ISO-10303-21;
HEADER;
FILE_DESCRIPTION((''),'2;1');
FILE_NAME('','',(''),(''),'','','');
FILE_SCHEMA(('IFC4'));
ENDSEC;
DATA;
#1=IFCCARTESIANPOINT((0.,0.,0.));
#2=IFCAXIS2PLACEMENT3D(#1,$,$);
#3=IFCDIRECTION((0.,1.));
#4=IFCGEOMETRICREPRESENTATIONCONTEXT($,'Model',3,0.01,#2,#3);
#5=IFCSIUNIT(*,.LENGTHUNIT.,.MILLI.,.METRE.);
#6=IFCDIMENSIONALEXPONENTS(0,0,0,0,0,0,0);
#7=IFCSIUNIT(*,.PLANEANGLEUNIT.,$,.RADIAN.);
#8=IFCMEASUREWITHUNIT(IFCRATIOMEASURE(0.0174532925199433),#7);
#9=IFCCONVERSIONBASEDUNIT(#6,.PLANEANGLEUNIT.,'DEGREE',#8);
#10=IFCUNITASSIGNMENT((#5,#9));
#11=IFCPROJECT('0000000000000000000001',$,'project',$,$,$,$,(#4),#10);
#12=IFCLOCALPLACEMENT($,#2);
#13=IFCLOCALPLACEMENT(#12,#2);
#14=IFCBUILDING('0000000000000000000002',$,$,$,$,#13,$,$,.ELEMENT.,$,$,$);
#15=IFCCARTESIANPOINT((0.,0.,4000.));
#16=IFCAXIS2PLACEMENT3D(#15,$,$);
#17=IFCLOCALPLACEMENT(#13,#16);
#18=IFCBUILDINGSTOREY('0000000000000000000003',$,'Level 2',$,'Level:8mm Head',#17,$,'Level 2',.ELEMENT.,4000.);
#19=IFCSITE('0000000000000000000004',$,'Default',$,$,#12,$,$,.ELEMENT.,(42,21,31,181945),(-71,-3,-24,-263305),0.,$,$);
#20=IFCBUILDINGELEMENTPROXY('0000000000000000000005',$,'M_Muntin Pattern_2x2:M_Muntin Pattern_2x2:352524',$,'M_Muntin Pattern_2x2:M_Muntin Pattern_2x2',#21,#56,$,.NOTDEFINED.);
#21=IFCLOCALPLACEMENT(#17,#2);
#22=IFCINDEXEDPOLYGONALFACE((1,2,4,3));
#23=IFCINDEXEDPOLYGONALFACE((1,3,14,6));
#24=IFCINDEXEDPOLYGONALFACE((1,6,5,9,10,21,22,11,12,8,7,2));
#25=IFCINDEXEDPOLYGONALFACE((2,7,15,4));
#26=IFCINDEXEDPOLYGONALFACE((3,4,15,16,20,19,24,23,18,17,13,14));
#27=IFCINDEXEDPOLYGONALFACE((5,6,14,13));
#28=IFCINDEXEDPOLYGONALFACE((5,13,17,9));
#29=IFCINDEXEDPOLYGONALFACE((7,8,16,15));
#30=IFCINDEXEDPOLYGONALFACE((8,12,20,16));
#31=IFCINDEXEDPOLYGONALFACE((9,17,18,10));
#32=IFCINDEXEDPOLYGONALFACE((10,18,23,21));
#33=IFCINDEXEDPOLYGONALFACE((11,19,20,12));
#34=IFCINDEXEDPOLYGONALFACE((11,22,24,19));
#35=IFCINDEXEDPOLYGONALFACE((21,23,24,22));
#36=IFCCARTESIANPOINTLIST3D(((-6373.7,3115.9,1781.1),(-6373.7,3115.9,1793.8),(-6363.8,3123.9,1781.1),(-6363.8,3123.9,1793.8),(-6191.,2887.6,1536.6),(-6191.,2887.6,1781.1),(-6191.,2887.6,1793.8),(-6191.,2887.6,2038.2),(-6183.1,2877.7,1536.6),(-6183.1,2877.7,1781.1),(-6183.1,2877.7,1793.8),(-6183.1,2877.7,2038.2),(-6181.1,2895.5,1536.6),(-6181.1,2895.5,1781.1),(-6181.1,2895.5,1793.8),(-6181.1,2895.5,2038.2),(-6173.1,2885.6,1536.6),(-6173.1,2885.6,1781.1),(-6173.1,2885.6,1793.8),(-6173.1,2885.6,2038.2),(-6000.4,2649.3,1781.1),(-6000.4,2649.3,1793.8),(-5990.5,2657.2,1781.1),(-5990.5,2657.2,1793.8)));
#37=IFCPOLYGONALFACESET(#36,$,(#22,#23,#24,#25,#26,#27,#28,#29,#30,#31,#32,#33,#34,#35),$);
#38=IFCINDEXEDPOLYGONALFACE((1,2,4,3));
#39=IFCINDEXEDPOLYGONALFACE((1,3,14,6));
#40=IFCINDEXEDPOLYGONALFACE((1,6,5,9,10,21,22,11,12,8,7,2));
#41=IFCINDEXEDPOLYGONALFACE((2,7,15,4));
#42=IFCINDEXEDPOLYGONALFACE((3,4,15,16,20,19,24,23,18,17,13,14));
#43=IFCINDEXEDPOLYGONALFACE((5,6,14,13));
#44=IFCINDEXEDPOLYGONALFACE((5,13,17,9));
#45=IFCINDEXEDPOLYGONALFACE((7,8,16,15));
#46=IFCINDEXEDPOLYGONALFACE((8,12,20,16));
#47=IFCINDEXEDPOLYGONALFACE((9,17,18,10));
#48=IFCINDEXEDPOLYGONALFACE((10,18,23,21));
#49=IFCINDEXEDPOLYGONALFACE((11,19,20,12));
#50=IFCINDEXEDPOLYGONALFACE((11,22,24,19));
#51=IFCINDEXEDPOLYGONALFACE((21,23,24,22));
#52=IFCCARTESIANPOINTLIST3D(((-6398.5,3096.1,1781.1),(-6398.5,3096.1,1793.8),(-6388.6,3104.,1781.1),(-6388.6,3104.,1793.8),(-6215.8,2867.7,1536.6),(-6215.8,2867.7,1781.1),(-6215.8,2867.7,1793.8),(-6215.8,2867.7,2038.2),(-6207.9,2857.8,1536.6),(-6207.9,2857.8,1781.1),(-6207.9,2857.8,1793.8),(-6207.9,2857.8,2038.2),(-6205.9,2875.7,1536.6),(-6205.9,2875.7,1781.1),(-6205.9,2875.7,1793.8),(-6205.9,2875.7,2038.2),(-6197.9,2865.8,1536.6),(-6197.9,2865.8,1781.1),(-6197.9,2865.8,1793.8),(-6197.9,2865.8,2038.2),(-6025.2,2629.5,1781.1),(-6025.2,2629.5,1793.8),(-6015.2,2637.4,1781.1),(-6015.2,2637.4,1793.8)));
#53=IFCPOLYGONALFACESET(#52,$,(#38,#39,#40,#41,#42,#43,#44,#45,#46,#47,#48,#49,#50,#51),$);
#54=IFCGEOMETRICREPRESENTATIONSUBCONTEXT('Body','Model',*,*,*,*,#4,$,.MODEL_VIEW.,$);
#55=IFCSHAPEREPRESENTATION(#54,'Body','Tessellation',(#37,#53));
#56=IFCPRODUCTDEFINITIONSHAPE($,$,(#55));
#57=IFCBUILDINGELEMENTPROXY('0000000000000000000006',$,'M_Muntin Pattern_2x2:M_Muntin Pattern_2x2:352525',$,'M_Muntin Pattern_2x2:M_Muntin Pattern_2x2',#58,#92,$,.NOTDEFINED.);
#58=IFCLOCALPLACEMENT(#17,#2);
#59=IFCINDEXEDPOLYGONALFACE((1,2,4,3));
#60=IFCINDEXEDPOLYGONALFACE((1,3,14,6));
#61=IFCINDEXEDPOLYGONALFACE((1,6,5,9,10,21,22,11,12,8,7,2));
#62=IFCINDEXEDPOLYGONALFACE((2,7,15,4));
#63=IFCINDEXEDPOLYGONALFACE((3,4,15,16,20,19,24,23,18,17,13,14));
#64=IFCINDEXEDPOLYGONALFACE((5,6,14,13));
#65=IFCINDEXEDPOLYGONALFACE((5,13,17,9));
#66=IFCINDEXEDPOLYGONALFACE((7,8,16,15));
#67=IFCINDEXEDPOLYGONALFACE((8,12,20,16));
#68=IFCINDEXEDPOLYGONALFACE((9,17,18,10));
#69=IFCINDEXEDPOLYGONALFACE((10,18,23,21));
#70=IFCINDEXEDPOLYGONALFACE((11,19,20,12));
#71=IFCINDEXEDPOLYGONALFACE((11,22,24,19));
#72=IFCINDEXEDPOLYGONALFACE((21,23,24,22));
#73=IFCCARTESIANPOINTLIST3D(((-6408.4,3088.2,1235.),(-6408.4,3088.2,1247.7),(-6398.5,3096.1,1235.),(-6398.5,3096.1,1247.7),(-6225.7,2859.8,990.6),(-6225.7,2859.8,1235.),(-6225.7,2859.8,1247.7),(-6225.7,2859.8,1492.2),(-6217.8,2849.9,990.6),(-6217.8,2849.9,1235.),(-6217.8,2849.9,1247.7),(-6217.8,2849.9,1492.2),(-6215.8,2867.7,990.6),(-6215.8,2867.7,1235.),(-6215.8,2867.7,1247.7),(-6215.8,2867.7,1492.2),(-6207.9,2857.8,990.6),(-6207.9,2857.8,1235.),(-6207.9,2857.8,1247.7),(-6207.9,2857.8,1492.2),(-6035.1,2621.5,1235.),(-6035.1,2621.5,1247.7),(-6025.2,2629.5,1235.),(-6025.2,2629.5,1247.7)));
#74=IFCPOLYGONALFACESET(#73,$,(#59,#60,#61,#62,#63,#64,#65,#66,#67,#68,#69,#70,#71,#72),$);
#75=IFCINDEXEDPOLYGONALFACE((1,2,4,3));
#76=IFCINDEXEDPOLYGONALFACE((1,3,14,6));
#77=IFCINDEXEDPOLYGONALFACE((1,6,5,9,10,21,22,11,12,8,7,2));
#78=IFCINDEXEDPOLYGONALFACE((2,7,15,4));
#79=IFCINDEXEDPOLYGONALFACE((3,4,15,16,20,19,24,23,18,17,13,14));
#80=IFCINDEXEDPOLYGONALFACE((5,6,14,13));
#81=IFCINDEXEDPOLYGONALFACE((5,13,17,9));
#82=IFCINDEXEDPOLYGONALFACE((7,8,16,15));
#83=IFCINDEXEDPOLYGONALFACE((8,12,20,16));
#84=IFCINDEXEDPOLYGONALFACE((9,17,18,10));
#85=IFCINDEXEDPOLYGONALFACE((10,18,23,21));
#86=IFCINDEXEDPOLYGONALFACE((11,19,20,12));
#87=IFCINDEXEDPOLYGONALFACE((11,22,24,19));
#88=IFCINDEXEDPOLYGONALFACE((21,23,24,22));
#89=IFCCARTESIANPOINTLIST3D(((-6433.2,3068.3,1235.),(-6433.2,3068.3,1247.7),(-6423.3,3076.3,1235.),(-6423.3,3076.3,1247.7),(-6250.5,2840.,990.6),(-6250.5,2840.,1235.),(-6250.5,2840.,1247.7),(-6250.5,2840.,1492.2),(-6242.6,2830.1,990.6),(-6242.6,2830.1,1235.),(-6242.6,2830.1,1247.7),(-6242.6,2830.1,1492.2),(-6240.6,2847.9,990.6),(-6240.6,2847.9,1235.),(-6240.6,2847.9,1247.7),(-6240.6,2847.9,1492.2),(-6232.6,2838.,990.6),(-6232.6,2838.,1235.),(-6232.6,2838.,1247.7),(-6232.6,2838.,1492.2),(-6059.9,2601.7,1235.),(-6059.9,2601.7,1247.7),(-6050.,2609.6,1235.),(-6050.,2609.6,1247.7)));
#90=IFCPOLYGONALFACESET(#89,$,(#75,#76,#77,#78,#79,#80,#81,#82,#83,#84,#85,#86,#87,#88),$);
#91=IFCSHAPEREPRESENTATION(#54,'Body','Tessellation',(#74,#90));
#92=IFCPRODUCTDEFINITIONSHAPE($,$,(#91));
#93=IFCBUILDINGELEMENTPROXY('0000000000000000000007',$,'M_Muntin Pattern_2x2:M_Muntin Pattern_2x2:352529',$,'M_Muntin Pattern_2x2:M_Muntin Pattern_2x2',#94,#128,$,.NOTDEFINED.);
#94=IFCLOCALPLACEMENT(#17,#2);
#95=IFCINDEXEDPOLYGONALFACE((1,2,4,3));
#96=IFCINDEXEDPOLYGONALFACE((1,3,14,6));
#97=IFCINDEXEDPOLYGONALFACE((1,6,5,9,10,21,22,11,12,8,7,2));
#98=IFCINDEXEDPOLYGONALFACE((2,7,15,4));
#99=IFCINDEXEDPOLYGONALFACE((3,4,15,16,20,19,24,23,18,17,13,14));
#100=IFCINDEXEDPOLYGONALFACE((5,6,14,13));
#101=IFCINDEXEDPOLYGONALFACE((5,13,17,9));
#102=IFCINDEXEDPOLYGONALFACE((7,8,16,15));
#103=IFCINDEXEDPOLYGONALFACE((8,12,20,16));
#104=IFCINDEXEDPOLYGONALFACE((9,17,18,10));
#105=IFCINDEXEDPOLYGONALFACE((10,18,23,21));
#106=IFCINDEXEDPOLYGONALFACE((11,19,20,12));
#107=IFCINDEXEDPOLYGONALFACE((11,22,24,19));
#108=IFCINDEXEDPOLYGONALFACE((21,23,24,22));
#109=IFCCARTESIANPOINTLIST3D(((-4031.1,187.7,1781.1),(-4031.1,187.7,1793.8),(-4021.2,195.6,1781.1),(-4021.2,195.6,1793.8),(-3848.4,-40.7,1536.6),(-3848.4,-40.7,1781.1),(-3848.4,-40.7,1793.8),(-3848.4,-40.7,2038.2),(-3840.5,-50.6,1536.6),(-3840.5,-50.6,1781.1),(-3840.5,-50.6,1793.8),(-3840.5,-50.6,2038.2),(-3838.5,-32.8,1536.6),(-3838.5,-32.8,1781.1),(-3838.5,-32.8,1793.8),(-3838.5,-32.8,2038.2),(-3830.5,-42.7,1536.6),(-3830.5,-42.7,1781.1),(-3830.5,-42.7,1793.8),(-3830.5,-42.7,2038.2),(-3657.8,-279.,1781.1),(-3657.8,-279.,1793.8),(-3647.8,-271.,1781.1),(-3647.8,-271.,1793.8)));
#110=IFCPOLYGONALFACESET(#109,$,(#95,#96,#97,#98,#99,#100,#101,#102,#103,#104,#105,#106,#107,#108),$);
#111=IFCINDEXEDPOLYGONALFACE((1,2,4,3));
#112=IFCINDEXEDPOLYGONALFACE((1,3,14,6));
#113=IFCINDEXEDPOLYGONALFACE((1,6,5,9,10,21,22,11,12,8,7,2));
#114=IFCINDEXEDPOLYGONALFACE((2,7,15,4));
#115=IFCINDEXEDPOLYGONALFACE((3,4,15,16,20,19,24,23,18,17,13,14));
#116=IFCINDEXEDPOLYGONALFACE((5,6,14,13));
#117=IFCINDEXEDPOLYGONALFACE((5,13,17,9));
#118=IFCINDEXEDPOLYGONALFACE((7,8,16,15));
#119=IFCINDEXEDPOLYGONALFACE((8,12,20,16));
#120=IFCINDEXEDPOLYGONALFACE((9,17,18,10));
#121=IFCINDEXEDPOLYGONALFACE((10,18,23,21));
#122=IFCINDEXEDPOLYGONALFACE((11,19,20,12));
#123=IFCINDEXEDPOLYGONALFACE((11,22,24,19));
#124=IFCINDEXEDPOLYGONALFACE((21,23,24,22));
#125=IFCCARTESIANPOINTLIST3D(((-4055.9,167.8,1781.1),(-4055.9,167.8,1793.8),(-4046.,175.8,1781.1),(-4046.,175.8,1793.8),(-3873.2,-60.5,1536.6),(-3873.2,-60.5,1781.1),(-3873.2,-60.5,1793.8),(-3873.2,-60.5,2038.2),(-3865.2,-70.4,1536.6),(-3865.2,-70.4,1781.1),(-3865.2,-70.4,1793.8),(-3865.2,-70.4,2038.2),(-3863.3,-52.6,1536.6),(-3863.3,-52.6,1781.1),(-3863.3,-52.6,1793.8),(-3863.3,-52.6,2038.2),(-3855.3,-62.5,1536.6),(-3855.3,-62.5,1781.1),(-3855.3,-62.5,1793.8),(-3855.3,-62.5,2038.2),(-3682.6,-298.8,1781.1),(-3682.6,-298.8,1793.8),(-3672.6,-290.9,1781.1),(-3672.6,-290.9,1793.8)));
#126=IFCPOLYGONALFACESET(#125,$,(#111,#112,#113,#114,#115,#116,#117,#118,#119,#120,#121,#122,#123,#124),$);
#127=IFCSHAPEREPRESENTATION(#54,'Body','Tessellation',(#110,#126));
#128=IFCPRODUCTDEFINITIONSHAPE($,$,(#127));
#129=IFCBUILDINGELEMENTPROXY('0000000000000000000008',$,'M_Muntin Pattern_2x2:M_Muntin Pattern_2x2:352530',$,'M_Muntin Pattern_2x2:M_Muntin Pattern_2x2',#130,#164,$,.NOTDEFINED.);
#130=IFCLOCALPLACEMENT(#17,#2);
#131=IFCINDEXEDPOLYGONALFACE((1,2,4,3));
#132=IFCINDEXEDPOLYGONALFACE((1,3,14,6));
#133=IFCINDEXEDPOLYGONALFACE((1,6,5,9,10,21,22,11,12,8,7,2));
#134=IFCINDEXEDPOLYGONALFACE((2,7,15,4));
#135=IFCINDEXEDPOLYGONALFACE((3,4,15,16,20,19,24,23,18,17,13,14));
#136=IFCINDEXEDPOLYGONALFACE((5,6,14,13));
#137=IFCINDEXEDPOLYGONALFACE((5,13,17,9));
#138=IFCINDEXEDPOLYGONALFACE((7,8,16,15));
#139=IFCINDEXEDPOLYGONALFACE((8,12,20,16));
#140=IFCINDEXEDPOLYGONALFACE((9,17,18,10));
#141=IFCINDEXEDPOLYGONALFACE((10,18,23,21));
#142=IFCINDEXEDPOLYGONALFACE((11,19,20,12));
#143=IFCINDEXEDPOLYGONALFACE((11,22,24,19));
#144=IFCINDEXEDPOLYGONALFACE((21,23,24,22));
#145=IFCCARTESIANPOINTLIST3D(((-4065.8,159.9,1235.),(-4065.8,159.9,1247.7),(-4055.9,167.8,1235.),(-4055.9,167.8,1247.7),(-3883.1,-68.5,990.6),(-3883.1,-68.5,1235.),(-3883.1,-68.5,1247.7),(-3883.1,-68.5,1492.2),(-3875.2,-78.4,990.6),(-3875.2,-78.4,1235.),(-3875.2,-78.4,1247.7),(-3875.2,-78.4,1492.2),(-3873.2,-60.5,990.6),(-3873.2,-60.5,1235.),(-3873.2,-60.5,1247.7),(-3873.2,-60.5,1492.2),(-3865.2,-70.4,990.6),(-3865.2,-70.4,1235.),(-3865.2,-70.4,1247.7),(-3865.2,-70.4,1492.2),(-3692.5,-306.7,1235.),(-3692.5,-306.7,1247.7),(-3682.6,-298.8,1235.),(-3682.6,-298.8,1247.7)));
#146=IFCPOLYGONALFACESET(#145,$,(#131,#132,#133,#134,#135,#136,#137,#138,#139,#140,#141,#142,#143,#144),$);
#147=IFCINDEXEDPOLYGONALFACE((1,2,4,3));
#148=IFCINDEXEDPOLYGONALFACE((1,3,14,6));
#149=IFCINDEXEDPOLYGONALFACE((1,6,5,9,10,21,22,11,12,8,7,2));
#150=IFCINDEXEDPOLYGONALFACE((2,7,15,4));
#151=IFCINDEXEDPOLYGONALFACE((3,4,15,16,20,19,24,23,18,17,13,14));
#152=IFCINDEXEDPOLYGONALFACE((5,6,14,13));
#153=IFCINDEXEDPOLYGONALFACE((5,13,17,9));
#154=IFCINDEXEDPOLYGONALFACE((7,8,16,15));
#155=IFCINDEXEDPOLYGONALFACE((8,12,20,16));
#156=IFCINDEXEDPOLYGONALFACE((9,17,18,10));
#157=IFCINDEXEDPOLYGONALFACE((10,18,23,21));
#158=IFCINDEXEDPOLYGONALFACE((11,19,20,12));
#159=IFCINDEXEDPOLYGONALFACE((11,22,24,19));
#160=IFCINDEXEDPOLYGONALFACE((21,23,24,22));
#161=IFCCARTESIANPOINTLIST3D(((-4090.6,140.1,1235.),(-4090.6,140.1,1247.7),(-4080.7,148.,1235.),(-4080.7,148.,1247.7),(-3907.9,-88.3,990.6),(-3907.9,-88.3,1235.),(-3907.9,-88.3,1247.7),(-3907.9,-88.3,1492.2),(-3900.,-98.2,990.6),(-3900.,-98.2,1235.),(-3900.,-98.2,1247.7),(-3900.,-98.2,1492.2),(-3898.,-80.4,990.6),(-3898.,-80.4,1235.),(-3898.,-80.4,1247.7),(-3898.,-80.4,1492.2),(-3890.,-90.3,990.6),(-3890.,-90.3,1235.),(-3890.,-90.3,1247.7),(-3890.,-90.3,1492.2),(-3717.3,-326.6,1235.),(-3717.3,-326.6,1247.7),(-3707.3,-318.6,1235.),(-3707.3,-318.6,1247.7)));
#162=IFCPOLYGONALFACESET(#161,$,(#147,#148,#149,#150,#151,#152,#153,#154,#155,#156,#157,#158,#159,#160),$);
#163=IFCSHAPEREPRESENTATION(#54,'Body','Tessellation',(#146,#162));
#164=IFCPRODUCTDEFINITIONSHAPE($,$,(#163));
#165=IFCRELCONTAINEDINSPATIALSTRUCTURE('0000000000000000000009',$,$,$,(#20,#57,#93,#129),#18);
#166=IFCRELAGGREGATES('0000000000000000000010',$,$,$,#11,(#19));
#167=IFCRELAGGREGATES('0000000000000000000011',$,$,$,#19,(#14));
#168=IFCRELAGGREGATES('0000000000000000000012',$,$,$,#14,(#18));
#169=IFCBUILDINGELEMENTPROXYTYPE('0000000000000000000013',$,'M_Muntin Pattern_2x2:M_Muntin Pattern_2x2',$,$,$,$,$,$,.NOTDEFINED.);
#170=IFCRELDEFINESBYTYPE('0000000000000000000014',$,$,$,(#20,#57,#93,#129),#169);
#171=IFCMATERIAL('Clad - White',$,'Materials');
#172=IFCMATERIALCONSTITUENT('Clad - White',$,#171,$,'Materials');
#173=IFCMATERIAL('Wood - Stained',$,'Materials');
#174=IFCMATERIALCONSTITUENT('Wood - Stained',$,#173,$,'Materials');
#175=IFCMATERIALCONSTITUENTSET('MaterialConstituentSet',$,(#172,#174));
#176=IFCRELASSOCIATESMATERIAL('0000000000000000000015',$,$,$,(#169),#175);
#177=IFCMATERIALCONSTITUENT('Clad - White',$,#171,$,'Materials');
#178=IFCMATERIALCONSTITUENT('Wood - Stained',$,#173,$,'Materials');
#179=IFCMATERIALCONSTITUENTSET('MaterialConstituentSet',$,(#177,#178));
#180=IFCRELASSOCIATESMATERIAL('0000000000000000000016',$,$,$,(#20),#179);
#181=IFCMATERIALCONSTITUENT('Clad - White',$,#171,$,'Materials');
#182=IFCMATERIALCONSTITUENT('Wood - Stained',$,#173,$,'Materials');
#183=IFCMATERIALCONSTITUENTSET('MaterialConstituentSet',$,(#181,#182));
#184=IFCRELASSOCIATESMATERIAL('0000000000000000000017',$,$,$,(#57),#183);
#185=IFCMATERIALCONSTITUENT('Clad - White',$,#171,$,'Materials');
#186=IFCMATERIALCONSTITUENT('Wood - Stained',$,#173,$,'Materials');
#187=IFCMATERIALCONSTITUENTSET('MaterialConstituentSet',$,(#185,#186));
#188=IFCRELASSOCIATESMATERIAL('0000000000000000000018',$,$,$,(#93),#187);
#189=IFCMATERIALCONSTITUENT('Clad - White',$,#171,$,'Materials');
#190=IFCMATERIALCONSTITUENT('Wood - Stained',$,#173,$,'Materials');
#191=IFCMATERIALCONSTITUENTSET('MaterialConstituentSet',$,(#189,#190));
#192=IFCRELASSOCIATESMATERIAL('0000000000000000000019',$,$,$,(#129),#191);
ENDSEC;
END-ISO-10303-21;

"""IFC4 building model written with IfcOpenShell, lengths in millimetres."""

from ifc_helpers import new_model, entity, si_unit, converted_unit, direction, frame, origin, place, context, subcontext, project, spatial, polyline, outline, extrude, source, transform, mapped, material, constituent, constituent_set, type_object, type_shapes, element, save


model = new_model("IFC4")

# Units and contexts
model_context = context("Model", 3, precision=0.01, world=origin(), true_north=direction((0.0, 1.0)))
body_context = subcontext(model_context, "Body", "Model", "MODEL_VIEW")
ifc_project = project(units=[si_unit("LENGTHUNIT", "METRE", prefix="MILLI"), converted_unit("PLANEANGLEUNIT", "DEGREE", entity("IfcRatioMeasure", 0.0174532925199433), si_unit("PLANEANGLEUNIT", "RADIAN"), dimensions=[0, 0, 0, 0, 0, 0, 0])], contexts=[model_context])

# Site, building, storey
site_placement = place(None, origin())
site = spatial("IfcSite", under=ifc_project, at=site_placement, Name="Default", CompositionType="ELEMENT", RefLatitude=(42, 21, 31, 181945), RefLongitude=(-71, -3, -24, -263305), RefElevation=0.0)
building_placement = place(site_placement, origin())
building = spatial("IfcBuilding", under=site, at=building_placement, CompositionType="ELEMENT")
storey_placement = place(building_placement, frame((0.0, 0.0, 4000.0)))
storey = spatial("IfcBuildingStorey", under=building, at=storey_placement, Name="Level 2", ObjectType="Level:8mm Head", LongName="Level 2", CompositionType="ELEMENT", Elevation=4000.0)

# Shared definitions
ifc_material_1 = material(Name="Wood - Stained", Category="Materials")

# Building element proxies
ifc_material_2 = material(Name="Clad - White", Category="Materials")
ifc_constituent_1 = constituent(ifc_material_2, Name="Clad - White", Category="Materials")
ifc_constituent_2 = constituent(ifc_material_1, Name="Wood - Stained", Category="Materials")
ifc_constituent_set_1 = constituent_set(constituents=[ifc_constituent_1, ifc_constituent_2], Name="MaterialConstituentSet")
building_element_proxy_type_1 = type_object("IfcBuildingElementProxyType", Name="M_Muntin Pattern_2x2:M_Muntin Pattern_2x2", PredefinedType="NOTDEFINED", material=ifc_constituent_set_1)
shared_shape_1 = source(origin(), body_context, "Body", "SweptSolid", [
    extrude(outline(polyline([(6.4, -6.4), (250.8, -6.4), (250.8, 6.3), (6.4, 6.3), (6.4, 298.8), (-6.3, 298.8), (-6.3, 6.3), (-250.8, 6.3), (-250.8, -6.4), (-6.3, -6.4), (-6.3, -298.8), (6.4, -298.8), (6.4, -6.4)])), frame((0.0, 9.5, 250.8), z_axis=(0.0, 1.0, 0.0), x_axis=(0.0, 0.0, 1.0)), (0.0, 0.0, 1.0), 12.7),
    extrude(outline(polyline([(6.4, -6.4), (250.8, -6.4), (250.8, 6.3), (6.4, 6.3), (6.4, 298.8), (-6.3, 298.8), (-6.3, 6.3), (-250.8, 6.3), (-250.8, -6.4), (-6.3, -6.4), (-6.3, -298.8), (6.4, -298.8), (6.4, -6.4)])), frame((0.0, -22.2, 250.8), z_axis=(0.0, 1.0, 0.0), x_axis=(0.0, 0.0, 1.0)), (0.0, 0.0, 1.0), 12.7),
])
type_shapes(building_element_proxy_type_1, [shared_shape_1])
ifc_constituent_3 = constituent(ifc_material_2, Name="Clad - White", Category="Materials")
ifc_constituent_4 = constituent(ifc_material_1, Name="Wood - Stained", Category="Materials")
ifc_constituent_set_2 = constituent_set(constituents=[ifc_constituent_3, ifc_constituent_4], Name="MaterialConstituentSet")
proxy_1_placement = place(storey_placement, frame((-6194.5, 2876.7, 1536.6), z_axis=(0.0, 0.0, 1.0), x_axis=(0.624695, -0.780869, 0.0)))
element("IfcBuildingElementProxy", 1, at=proxy_1_placement, inside=storey, type_object=building_element_proxy_type_1, material=ifc_constituent_set_2, Name="M_Muntin Pattern_2x2:M_Muntin Pattern_2x2:352524", ObjectType="M_Muntin Pattern_2x2:M_Muntin Pattern_2x2", PredefinedType="NOTDEFINED", context=body_context, shape_type="MappedRepresentation", body=[
    mapped(shared_shape_1, transform((0.0, 0.0, 0.0), scale=1.0)),
])
ifc_constituent_5 = constituent(ifc_material_2, Name="Clad - White", Category="Materials")
ifc_constituent_6 = constituent(ifc_material_1, Name="Wood - Stained", Category="Materials")
ifc_constituent_set_3 = constituent_set(constituents=[ifc_constituent_5, ifc_constituent_6], Name="MaterialConstituentSet")
proxy_2_placement = place(storey_placement, frame((-6229.2, 2848.9, 990.6), z_axis=(0.0, 0.0, 1.0), x_axis=(0.624695, -0.780869, 0.0)))
element("IfcBuildingElementProxy", 2, at=proxy_2_placement, inside=storey, type_object=building_element_proxy_type_1, material=ifc_constituent_set_3, Name="M_Muntin Pattern_2x2:M_Muntin Pattern_2x2:352525", ObjectType="M_Muntin Pattern_2x2:M_Muntin Pattern_2x2", PredefinedType="NOTDEFINED", context=body_context, shape_type="MappedRepresentation", body=[
    mapped(shared_shape_1, transform((0.0, 0.0, 0.0), scale=1.0)),
])
ifc_constituent_7 = constituent(ifc_material_2, Name="Clad - White", Category="Materials")
ifc_constituent_8 = constituent(ifc_material_1, Name="Wood - Stained", Category="Materials")
ifc_constituent_set_4 = constituent_set(constituents=[ifc_constituent_7, ifc_constituent_8], Name="MaterialConstituentSet")
proxy_3_placement = place(storey_placement, frame((-3851.9, -51.6, 1536.6), z_axis=(0.0, 0.0, 1.0), x_axis=(0.624695, -0.780869, 0.0)))
element("IfcBuildingElementProxy", 3, at=proxy_3_placement, inside=storey, type_object=building_element_proxy_type_1, material=ifc_constituent_set_4, Name="M_Muntin Pattern_2x2:M_Muntin Pattern_2x2:352529", ObjectType="M_Muntin Pattern_2x2:M_Muntin Pattern_2x2", PredefinedType="NOTDEFINED", context=body_context, shape_type="MappedRepresentation", body=[
    mapped(shared_shape_1, transform((0.0, 0.0, 0.0), scale=1.0)),
])
ifc_constituent_9 = constituent(ifc_material_2, Name="Clad - White", Category="Materials")
ifc_constituent_10 = constituent(ifc_material_1, Name="Wood - Stained", Category="Materials")
ifc_constituent_set_5 = constituent_set(constituents=[ifc_constituent_9, ifc_constituent_10], Name="MaterialConstituentSet")
proxy_4_placement = place(storey_placement, frame((-3886.6, -79.4, 990.6), z_axis=(0.0, 0.0, 1.0), x_axis=(0.624695, -0.780869, 0.0)))
element("IfcBuildingElementProxy", 4, at=proxy_4_placement, inside=storey, type_object=building_element_proxy_type_1, material=ifc_constituent_set_5, Name="M_Muntin Pattern_2x2:M_Muntin Pattern_2x2:352530", ObjectType="M_Muntin Pattern_2x2:M_Muntin Pattern_2x2", PredefinedType="NOTDEFINED", context=body_context, shape_type="MappedRepresentation", body=[
    mapped(shared_shape_1, transform((0.0, 0.0, 0.0), scale=1.0)),
])

save(model, "model.ifc")
